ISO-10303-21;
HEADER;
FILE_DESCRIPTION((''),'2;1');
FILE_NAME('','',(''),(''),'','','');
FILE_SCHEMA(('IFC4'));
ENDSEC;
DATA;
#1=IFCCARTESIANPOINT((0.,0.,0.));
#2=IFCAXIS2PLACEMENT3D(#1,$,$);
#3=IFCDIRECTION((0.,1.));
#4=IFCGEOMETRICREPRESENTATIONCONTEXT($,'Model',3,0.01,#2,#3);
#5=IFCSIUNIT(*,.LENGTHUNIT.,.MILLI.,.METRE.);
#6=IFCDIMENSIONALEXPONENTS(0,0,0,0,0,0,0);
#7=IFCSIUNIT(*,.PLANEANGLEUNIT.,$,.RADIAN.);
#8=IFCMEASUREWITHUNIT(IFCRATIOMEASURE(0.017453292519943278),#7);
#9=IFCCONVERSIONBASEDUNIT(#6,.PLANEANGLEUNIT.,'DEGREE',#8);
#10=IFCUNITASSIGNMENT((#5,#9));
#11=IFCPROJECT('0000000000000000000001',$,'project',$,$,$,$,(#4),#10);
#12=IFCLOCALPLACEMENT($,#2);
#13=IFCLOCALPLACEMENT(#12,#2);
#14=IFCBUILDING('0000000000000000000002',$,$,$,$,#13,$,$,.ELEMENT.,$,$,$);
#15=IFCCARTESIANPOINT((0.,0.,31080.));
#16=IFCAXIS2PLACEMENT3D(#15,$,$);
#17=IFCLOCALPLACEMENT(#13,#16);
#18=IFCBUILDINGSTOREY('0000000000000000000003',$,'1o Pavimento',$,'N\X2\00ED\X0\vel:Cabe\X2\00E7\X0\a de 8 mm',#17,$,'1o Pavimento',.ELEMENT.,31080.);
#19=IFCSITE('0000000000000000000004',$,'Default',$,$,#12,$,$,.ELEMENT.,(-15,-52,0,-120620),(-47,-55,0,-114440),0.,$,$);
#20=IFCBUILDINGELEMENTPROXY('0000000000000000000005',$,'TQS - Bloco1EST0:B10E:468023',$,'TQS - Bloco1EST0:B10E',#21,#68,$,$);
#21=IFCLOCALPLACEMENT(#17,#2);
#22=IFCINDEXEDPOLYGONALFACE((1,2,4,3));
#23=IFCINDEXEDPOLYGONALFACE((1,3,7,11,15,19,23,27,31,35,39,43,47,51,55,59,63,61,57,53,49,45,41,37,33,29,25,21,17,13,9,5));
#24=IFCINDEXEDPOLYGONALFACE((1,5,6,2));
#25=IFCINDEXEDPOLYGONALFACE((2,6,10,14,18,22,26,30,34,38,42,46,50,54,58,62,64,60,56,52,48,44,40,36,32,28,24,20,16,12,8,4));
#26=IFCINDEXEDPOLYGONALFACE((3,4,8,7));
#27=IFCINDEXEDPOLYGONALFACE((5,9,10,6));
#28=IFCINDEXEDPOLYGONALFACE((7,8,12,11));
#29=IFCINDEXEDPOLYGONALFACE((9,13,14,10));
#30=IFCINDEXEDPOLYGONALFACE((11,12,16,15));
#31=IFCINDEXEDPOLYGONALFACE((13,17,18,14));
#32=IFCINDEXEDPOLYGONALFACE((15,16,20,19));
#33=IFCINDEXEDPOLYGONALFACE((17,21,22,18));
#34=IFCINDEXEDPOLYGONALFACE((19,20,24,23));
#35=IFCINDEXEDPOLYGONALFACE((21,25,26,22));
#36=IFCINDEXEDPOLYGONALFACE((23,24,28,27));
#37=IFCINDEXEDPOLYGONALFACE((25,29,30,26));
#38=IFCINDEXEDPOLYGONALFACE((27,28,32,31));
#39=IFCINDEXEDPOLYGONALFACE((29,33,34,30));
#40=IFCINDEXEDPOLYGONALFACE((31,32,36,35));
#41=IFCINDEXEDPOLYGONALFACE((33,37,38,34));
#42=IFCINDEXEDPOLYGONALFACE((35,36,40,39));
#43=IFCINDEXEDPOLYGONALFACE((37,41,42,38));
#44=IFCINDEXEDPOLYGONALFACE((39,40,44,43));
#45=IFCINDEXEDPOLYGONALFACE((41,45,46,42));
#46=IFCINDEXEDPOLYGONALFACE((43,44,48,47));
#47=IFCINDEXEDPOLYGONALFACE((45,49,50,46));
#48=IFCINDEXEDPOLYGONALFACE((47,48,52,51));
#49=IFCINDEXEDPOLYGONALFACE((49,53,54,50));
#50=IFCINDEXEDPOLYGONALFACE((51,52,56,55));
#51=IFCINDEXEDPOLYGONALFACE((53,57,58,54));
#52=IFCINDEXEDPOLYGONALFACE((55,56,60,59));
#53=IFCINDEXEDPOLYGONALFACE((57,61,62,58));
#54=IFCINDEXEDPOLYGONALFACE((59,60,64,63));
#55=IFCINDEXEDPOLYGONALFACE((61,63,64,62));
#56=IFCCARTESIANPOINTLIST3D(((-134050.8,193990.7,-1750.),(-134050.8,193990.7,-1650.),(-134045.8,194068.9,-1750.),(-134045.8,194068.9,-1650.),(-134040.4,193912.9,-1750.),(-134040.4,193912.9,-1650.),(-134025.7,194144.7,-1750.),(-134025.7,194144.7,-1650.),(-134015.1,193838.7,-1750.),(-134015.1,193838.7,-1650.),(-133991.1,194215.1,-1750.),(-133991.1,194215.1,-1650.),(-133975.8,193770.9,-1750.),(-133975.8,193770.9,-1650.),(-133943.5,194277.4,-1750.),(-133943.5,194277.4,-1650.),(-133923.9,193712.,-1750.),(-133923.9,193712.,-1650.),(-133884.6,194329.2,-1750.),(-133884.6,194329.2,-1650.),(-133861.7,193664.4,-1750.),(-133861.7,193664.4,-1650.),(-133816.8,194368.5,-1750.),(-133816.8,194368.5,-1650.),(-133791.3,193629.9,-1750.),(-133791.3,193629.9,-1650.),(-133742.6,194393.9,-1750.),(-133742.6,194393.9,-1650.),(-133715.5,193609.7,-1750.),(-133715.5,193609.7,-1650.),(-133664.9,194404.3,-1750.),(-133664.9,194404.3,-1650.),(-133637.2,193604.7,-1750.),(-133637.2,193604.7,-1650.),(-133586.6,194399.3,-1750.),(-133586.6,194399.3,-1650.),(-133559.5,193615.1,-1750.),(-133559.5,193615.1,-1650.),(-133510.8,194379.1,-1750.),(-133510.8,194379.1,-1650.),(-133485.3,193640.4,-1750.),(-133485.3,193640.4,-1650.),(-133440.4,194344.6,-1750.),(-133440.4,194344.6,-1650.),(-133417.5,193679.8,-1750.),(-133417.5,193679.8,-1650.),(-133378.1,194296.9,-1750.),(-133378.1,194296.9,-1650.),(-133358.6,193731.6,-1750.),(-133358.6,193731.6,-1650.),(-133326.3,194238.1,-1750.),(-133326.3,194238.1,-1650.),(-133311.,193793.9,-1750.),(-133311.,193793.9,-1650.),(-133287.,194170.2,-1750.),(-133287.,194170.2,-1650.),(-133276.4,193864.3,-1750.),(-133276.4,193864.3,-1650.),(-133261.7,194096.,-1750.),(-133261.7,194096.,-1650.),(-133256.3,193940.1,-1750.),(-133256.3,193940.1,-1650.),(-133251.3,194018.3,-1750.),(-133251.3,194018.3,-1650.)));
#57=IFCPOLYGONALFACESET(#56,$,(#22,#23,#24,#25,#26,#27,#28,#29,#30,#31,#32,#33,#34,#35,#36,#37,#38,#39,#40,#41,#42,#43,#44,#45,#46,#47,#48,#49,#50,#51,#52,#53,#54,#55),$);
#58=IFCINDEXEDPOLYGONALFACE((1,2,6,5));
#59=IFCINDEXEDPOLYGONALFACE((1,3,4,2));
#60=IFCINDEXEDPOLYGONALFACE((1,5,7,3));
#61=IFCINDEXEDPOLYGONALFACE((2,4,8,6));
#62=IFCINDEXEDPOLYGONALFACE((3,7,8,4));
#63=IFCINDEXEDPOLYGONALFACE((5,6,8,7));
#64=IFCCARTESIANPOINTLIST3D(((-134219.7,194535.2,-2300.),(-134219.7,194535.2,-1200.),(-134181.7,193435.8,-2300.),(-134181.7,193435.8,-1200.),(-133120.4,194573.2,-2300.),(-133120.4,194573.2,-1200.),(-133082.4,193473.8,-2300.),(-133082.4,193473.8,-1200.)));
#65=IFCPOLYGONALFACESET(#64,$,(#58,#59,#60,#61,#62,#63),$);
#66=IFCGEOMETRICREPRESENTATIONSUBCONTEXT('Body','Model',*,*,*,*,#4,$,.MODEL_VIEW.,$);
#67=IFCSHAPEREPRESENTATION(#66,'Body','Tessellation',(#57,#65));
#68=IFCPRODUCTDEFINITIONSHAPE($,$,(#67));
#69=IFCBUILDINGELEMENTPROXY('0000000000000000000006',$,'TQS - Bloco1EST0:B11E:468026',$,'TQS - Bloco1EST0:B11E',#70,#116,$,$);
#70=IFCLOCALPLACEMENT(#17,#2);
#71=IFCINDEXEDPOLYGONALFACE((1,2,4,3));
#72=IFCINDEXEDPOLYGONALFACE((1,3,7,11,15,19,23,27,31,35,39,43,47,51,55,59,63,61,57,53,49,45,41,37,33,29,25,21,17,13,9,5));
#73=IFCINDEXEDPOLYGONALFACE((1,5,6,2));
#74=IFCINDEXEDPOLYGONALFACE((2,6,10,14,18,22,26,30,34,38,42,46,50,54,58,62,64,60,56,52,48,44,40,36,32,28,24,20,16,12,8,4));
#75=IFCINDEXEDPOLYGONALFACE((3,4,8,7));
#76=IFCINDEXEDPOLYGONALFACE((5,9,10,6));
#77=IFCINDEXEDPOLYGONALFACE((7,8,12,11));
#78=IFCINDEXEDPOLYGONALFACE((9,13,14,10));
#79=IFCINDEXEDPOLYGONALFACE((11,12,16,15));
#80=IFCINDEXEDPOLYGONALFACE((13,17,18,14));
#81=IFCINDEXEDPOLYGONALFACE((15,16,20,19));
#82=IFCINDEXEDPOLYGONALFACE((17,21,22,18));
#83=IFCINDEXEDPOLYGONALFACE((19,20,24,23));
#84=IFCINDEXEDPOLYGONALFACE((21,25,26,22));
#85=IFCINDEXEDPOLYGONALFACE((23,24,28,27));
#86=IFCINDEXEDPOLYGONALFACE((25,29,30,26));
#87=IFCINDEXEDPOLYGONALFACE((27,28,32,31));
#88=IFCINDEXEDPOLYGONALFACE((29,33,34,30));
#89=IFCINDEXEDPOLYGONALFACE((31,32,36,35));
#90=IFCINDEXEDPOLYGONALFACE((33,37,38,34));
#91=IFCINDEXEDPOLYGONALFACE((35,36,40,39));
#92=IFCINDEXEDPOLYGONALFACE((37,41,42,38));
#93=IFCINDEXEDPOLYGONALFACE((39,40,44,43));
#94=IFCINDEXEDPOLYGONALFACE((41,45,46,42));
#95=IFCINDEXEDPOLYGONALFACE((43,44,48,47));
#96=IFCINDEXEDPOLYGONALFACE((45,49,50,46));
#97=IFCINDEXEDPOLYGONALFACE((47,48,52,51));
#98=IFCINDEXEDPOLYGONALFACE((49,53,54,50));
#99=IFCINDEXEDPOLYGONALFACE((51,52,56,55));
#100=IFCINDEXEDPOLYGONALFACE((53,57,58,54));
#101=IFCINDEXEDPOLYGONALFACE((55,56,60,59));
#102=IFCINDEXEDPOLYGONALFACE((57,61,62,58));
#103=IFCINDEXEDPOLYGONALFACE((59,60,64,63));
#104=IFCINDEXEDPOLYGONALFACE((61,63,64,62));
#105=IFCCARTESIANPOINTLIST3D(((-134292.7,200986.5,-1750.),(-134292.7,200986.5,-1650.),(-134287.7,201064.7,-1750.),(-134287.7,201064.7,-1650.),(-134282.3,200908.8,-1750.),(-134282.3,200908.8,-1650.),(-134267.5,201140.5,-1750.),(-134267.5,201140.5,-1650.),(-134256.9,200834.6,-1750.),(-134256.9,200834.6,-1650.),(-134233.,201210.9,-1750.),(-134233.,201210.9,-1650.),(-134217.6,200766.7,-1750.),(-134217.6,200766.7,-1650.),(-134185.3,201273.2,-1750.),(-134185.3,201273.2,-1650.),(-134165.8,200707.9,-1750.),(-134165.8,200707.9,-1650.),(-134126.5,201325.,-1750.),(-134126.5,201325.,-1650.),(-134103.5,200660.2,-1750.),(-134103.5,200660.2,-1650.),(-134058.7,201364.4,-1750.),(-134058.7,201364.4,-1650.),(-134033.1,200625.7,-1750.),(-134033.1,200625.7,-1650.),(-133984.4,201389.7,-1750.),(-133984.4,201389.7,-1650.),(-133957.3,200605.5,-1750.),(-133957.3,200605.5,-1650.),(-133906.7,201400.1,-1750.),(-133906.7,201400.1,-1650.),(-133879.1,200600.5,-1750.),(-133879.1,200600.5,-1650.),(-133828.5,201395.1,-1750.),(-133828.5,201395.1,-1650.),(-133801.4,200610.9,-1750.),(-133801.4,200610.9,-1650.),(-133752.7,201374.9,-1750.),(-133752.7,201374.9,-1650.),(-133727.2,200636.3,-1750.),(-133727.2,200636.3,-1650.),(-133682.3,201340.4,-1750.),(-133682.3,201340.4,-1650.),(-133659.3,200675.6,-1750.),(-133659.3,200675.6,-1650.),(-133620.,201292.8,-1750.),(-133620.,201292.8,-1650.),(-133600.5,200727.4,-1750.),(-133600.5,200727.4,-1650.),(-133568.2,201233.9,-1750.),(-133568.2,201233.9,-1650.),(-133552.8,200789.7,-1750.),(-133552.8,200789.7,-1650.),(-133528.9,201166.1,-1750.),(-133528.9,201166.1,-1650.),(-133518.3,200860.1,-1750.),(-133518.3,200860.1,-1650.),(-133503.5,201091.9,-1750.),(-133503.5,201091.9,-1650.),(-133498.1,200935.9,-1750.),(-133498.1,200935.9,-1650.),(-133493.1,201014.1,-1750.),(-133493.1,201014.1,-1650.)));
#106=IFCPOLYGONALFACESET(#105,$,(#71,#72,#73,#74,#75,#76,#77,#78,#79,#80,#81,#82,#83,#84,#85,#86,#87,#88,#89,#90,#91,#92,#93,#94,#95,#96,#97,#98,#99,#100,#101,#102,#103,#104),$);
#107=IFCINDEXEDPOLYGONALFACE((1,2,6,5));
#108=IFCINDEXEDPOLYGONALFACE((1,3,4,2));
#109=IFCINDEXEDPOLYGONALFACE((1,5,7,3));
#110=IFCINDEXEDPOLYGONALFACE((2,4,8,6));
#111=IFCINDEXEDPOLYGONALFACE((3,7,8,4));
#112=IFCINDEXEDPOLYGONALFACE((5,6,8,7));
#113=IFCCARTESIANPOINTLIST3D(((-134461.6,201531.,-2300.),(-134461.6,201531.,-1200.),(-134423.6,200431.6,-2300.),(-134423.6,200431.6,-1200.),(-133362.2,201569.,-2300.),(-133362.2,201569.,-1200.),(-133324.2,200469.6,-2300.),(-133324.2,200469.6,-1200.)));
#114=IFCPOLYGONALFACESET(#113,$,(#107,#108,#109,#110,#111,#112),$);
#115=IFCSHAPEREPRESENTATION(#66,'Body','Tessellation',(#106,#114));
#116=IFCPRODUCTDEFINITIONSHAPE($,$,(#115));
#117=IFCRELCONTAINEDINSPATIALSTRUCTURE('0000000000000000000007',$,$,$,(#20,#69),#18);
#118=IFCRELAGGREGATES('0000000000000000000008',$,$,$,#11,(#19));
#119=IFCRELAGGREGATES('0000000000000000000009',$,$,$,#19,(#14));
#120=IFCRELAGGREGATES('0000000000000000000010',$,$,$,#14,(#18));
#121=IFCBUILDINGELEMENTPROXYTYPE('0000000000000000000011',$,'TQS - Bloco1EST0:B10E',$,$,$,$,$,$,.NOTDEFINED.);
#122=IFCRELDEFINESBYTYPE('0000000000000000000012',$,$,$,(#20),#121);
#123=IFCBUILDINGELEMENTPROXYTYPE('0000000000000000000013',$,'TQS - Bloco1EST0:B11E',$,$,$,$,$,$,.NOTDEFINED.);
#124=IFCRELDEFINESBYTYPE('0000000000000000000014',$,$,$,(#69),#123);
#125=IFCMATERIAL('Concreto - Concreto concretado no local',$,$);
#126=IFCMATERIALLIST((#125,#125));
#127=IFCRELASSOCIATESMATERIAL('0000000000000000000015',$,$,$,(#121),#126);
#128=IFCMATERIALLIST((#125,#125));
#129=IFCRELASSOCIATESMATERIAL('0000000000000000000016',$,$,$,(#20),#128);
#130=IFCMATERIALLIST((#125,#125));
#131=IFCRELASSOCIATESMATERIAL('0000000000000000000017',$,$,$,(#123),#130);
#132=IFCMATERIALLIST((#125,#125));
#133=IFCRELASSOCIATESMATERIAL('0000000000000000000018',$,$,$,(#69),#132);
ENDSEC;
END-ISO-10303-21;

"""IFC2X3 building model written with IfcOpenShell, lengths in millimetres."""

from ifc_helpers import new_model, entity, si_unit, converted_unit, direction, frame, frame_2d, origin, origin_2d_with_axis, place, context, subcontext, project, spatial, rectangle, circle, extrude, source, transform, mapped, material, material_list, type_object, type_shapes, element, save


model = new_model("IFC2X3")

# Units and contexts
model_context = context("Model", 3, precision=0.01, world=origin(), true_north=direction((0.0, 1.0)))
body_context = subcontext(model_context, "Body", "Model", "MODEL_VIEW")
ifc_project = project(units=[si_unit("LENGTHUNIT", "METRE", prefix="MILLI"), converted_unit("PLANEANGLEUNIT", "DEGREE", entity("IfcRatioMeasure", 0.017453292519943278), si_unit("PLANEANGLEUNIT", "RADIAN"), dimensions=[0, 0, 0, 0, 0, 0, 0])], contexts=[model_context])

# Site, building, storey
site_placement = place(None, origin())
site = spatial("IfcSite", under=ifc_project, at=site_placement, Name="Default", CompositionType="ELEMENT", RefLatitude=(-15, -52, 0, -120620), RefLongitude=(-47, -55, 0, -114440), RefElevation=0.0)
building_placement = place(site_placement, origin())
building = spatial("IfcBuilding", under=site, at=building_placement, CompositionType="ELEMENT")
storey_placement = place(building_placement, frame((0.0, 0.0, 31080.0)))
storey = spatial("IfcBuildingStorey", under=building, at=storey_placement, Name="1o Pavimento", ObjectType="Nível:Cabeça de 8 mm", LongName="1o Pavimento", CompositionType="ELEMENT", Elevation=31080.0)

# Building element proxies
ifc_material_1 = material(Name="Concreto - Concreto concretado no local")
ifc_material_list_1 = material_list([ifc_material_1, ifc_material_1])
ifc_material_list_2 = material_list([ifc_material_1, ifc_material_1])
building_element_proxy_type_1 = type_object("IfcBuildingElementProxyType", Name="TQS - Bloco1EST0:B10E", PredefinedType="NOTDEFINED", material=ifc_material_list_2)
shared_shape_1 = source(origin(), body_context, "Body", "SweptSolid", [
    extrude(circle(Radius=400.0, at=frame_2d((0.0, 0.0), x_axis=(1.0, 0.0))), frame((0.0, 0.0, -550.0)), (0.0, 0.0, 1.0), 100.0),
    extrude(rectangle(XDim=1100.0, YDim=1100.0, at=origin_2d_with_axis()), frame((0.0, 0.0, -1100.0), z_axis=(0.0, 0.0, 1.0), x_axis=(-1.0, 0.0, 0.0)), (0.0, 0.0, 1.0), 1100.0),
])
type_shapes(building_element_proxy_type_1, [shared_shape_1])
proxy_1_placement = place(storey_placement, frame((-133651.0, 194004.5, -1200.0), z_axis=(0.0, 0.0, 1.0), x_axis=(-0.034551, 0.999403, 0.0)))
element("IfcBuildingElementProxy", 1, at=proxy_1_placement, inside=storey, type_object=building_element_proxy_type_1, material=ifc_material_list_1, Name="TQS - Bloco1EST0:B10E:468023", ObjectType="TQS - Bloco1EST0:B10E", context=body_context, shape_type="MappedRepresentation", body=[
    mapped(shared_shape_1, transform((0.0, 0.0, 0.0), scale=1.0)),
])
ifc_material_list_3 = material_list([ifc_material_1, ifc_material_1])
ifc_material_list_4 = material_list([ifc_material_1, ifc_material_1])
building_element_proxy_type_2 = type_object("IfcBuildingElementProxyType", Name="TQS - Bloco1EST0:B11E", PredefinedType="NOTDEFINED", material=ifc_material_list_4)
shared_shape_2 = source(origin(), body_context, "Body", "SweptSolid", [
    extrude(circle(Radius=400.0, at=frame_2d((0.0, 0.0), x_axis=(1.0, 0.0))), frame((0.0, 0.0, -550.0)), (0.0, 0.0, 1.0), 100.0),
    extrude(rectangle(XDim=1100.0, YDim=1100.0, at=origin_2d_with_axis()), frame((0.0, 0.0, -1100.0), z_axis=(0.0, 0.0, 1.0), x_axis=(-1.0, 0.0, 0.0)), (0.0, 0.0, 1.0), 1100.0),
])
type_shapes(building_element_proxy_type_2, [shared_shape_2])
proxy_2_placement = place(storey_placement, frame((-133892.9, 201000.3, -1200.0), z_axis=(0.0, 0.0, 1.0), x_axis=(-0.034551, 0.999403, 0.0)))
element("IfcBuildingElementProxy", 2, at=proxy_2_placement, inside=storey, type_object=building_element_proxy_type_2, material=ifc_material_list_3, Name="TQS - Bloco1EST0:B11E:468026", ObjectType="TQS - Bloco1EST0:B11E", context=body_context, shape_type="MappedRepresentation", body=[
    mapped(shared_shape_2, transform((0.0, 0.0, 0.0), scale=1.0)),
])

save(model, "model.ifc")
